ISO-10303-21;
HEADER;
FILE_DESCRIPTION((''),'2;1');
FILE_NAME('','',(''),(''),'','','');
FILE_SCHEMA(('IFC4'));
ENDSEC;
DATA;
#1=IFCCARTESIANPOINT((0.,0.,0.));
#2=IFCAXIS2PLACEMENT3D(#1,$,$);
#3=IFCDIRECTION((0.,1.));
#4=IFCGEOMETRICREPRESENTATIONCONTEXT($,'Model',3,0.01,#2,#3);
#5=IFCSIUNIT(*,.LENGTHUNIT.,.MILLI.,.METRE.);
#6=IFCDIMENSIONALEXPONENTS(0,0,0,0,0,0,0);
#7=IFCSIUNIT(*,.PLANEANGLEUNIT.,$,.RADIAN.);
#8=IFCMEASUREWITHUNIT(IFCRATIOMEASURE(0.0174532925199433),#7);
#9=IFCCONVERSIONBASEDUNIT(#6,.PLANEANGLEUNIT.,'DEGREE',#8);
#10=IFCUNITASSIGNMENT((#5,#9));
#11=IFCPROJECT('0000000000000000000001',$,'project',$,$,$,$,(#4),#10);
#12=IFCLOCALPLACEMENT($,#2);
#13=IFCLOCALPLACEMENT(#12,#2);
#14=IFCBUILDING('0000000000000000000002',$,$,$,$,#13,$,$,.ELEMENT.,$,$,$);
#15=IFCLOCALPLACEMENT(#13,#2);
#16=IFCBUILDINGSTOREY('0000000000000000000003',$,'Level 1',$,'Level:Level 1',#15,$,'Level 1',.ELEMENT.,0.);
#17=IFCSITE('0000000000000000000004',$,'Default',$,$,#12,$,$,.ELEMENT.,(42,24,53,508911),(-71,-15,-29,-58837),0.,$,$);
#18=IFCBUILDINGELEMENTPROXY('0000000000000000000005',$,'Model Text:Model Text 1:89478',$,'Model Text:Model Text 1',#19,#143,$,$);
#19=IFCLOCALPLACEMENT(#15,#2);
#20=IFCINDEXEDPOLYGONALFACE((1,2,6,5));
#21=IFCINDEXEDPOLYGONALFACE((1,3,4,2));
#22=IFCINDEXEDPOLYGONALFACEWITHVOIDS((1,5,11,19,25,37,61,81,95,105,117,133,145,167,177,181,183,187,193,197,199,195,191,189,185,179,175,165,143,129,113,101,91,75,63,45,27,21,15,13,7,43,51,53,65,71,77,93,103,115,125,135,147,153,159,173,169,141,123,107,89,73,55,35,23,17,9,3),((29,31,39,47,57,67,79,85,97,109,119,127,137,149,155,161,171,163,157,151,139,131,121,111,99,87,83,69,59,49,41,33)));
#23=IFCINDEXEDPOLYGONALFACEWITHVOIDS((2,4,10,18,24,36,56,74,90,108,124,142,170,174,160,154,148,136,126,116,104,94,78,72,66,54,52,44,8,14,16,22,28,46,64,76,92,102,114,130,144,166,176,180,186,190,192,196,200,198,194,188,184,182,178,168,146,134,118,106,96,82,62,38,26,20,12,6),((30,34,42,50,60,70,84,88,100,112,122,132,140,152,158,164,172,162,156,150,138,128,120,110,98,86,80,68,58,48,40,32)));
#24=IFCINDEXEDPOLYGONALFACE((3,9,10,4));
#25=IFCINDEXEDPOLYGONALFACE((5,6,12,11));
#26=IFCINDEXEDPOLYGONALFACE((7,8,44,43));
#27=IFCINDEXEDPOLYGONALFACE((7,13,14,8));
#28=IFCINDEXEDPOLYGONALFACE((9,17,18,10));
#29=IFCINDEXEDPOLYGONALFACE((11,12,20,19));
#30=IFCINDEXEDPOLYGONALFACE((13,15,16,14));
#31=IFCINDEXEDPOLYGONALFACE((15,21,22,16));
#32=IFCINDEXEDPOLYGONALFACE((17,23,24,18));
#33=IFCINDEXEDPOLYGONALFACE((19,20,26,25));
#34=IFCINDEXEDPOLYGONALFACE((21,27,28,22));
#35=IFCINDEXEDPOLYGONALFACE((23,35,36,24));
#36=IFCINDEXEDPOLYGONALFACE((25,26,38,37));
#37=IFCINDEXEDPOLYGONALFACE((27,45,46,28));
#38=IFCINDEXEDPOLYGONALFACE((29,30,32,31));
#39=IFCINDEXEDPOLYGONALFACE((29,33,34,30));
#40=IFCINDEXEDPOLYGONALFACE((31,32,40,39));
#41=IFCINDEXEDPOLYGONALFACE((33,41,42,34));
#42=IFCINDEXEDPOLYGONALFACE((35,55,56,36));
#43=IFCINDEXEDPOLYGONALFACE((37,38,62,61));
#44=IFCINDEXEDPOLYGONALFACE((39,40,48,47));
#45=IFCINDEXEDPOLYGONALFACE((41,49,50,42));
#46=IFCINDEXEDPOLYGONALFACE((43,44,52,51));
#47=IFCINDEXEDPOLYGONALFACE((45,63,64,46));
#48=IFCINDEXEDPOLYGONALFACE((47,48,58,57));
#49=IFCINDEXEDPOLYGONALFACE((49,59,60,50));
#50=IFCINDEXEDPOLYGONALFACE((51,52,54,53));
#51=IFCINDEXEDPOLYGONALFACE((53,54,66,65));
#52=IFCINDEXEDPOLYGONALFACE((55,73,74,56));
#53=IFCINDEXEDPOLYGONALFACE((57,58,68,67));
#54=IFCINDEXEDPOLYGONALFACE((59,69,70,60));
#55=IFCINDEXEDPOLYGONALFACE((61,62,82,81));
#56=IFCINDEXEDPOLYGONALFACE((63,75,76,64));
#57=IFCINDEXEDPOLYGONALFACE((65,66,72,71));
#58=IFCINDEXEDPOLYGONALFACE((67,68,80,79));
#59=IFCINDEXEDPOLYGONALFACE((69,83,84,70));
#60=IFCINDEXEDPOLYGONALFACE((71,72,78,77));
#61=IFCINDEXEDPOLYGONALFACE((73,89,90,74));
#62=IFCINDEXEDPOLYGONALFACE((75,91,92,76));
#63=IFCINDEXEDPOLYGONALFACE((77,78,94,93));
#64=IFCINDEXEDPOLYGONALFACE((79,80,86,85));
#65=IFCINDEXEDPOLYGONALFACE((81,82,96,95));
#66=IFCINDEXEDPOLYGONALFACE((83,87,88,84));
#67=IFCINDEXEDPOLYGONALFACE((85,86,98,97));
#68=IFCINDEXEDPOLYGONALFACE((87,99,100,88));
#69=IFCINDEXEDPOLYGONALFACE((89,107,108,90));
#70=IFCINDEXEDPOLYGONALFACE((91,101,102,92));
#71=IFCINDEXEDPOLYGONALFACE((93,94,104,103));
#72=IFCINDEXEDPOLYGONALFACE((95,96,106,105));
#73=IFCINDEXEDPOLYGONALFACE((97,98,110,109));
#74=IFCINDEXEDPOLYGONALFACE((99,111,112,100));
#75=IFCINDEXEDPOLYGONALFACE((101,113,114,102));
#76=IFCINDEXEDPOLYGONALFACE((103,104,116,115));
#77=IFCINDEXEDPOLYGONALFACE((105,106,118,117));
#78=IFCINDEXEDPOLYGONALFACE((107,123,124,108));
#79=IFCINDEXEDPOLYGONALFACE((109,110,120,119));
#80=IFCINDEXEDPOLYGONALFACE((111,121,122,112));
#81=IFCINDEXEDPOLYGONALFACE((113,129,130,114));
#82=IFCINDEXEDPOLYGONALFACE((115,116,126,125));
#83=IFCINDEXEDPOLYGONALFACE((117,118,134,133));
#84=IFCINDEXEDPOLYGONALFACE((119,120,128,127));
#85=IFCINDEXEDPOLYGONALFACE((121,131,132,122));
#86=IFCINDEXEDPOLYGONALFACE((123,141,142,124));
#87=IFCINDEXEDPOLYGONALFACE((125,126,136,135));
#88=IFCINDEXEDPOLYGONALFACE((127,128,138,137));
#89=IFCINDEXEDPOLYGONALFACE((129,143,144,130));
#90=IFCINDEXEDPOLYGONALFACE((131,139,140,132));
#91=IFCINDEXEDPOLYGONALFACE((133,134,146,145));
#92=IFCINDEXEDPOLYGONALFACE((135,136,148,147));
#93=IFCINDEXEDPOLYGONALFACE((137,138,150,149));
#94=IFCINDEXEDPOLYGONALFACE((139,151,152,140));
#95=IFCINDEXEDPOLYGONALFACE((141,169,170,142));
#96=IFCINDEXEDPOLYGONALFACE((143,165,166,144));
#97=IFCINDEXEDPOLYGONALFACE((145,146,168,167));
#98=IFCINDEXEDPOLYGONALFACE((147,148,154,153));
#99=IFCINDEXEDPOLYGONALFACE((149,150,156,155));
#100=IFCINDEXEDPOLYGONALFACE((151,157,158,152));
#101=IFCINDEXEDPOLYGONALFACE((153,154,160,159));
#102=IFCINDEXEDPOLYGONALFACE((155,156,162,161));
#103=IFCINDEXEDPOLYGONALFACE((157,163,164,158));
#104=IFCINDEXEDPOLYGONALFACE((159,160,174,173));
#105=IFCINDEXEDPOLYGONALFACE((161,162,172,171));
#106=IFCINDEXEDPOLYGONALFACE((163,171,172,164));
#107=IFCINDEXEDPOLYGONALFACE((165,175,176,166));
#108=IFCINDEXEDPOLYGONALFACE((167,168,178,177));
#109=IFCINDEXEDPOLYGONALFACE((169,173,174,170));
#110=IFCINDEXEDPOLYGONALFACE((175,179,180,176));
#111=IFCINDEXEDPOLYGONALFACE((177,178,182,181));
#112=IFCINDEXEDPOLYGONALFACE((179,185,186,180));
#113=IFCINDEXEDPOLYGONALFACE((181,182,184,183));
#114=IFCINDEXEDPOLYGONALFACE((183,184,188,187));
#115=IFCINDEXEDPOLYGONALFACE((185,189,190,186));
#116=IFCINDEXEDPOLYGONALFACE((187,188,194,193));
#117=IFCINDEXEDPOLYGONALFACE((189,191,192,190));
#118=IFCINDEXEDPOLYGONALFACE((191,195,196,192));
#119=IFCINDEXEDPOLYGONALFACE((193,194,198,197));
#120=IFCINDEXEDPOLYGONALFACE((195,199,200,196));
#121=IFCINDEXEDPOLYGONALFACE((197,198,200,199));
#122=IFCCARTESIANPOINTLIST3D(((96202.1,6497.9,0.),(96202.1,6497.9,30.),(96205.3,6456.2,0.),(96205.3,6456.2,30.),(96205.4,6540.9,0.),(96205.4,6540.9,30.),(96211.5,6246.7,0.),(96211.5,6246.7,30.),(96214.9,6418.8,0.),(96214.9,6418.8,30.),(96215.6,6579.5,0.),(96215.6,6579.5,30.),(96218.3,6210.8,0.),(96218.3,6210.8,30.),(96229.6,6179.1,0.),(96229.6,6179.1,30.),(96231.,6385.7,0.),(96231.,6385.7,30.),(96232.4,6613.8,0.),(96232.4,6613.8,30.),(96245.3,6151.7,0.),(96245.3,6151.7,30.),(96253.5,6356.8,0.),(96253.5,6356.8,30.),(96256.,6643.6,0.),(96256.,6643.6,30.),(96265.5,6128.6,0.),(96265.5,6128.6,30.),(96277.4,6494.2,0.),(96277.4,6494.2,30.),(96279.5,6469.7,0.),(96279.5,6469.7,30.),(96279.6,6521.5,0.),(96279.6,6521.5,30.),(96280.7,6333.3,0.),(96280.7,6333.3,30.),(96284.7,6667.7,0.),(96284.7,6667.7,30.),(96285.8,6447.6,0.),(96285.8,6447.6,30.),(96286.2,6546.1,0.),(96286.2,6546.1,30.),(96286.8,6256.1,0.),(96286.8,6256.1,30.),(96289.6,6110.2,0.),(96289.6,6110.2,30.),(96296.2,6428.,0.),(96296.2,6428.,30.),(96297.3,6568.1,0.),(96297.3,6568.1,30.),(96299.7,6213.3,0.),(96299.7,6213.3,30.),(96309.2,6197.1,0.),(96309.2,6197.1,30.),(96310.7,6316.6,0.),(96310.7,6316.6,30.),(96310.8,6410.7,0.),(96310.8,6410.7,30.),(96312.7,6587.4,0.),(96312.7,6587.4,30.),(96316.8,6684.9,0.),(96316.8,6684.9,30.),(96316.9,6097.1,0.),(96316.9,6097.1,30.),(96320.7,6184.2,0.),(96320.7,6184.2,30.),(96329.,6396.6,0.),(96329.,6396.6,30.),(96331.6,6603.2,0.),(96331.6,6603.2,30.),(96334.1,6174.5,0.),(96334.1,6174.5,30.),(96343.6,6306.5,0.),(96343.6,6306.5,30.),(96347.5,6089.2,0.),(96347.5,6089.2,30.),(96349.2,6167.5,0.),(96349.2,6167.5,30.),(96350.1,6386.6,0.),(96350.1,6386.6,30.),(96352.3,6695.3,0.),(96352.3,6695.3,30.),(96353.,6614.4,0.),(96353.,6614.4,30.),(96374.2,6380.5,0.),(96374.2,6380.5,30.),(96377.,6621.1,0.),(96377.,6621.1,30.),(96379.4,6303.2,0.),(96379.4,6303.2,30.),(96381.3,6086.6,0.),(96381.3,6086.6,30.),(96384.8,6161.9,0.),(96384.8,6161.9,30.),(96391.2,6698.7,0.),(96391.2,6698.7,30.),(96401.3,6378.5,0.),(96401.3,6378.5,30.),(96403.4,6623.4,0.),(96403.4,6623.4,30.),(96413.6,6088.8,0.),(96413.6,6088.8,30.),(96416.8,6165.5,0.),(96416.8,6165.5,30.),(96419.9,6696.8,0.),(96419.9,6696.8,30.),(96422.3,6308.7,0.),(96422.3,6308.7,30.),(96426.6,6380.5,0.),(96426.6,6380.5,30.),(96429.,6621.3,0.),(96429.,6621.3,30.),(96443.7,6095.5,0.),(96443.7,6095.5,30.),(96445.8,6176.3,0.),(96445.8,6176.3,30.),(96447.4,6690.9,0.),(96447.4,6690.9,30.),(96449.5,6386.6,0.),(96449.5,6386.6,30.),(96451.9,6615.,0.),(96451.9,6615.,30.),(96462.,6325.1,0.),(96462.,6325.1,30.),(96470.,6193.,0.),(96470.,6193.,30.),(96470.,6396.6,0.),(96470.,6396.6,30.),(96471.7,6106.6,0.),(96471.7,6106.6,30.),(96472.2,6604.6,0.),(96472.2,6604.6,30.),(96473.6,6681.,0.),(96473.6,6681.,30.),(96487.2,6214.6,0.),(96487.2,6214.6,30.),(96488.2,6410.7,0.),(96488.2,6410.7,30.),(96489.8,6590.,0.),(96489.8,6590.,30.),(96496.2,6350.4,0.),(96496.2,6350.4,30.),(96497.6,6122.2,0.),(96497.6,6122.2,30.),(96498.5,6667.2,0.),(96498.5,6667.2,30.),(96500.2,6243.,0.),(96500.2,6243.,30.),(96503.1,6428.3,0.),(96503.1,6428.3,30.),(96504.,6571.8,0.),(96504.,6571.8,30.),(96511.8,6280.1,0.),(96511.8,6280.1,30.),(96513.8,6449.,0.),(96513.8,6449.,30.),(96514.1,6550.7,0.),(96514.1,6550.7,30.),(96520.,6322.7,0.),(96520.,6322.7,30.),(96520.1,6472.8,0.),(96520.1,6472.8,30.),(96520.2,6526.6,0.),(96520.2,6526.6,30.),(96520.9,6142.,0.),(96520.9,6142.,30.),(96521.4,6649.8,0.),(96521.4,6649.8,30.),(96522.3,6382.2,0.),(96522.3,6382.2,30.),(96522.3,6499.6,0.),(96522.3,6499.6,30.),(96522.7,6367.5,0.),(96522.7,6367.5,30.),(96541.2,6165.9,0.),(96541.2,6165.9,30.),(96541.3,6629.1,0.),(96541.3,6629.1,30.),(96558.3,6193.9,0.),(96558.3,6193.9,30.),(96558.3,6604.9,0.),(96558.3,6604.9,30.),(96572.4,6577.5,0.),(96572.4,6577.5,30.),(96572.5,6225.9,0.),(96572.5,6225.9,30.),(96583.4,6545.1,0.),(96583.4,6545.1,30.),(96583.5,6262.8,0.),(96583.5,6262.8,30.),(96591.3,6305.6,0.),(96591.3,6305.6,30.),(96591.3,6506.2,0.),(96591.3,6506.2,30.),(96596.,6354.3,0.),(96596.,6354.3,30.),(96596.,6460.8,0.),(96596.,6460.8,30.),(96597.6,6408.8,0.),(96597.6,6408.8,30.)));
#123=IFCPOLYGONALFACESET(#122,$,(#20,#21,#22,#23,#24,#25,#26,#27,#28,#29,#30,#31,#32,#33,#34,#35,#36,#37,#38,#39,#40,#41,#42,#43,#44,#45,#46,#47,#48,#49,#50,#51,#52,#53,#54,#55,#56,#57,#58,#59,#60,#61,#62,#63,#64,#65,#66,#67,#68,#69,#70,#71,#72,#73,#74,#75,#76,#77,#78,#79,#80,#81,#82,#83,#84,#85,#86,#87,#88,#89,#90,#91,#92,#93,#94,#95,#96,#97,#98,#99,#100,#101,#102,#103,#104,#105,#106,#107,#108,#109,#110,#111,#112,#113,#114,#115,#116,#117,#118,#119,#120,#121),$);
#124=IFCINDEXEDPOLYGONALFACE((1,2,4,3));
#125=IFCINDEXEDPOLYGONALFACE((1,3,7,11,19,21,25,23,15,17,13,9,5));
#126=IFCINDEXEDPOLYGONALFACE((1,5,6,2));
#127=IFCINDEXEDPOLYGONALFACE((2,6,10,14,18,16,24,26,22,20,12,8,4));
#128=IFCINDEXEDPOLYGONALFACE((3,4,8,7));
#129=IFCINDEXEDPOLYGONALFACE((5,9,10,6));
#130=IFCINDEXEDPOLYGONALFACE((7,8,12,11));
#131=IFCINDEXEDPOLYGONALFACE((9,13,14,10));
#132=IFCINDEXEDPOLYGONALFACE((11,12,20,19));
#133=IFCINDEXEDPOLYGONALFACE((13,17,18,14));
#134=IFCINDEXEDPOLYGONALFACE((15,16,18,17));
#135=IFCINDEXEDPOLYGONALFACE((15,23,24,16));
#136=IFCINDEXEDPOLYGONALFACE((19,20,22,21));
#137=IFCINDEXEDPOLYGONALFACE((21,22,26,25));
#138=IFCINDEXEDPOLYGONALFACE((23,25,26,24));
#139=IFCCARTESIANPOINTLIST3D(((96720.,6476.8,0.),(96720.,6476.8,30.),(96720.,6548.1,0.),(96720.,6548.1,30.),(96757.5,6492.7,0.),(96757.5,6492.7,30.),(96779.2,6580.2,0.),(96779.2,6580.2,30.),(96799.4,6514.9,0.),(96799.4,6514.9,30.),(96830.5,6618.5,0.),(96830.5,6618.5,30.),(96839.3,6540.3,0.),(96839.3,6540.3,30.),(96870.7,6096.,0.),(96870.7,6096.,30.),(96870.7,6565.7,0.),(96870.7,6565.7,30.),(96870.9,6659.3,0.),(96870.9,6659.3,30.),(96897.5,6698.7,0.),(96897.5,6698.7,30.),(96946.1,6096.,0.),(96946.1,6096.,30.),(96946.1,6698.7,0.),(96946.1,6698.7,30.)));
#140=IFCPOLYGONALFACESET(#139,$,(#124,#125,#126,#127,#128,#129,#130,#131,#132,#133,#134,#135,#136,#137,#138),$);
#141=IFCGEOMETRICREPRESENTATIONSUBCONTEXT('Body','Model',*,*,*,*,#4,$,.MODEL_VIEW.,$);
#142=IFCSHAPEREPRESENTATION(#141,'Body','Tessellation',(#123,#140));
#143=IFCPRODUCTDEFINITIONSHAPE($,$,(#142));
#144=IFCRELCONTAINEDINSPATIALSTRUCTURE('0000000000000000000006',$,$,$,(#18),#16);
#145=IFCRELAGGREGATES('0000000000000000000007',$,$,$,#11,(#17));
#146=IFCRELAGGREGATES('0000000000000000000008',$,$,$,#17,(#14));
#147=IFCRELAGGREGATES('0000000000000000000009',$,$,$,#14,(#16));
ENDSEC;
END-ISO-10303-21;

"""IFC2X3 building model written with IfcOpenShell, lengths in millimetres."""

from ifc_helpers import new_model, entity, si_unit, converted_unit, direction, frame, origin, place, context, subcontext, project, spatial, polyline, outline, extrude, element, save


model = new_model("IFC2X3")

# Units and contexts
model_context = context("Model", 3, precision=0.01, world=origin(), true_north=direction((0.0, 1.0)))
body_context = subcontext(model_context, "Body", "Model", "MODEL_VIEW")
ifc_project = project(units=[si_unit("LENGTHUNIT", "METRE", prefix="MILLI"), converted_unit("PLANEANGLEUNIT", "DEGREE", entity("IfcRatioMeasure", 0.0174532925199433), si_unit("PLANEANGLEUNIT", "RADIAN"), dimensions=[0, 0, 0, 0, 0, 0, 0])], contexts=[model_context])

# Site, building, storey
site_placement = place(None, origin())
site = spatial("IfcSite", under=ifc_project, at=site_placement, Name="Default", CompositionType="ELEMENT", RefLatitude=(42, 24, 53, 508911), RefLongitude=(-71, -15, -29, -58837), RefElevation=0.0)
building_placement = place(site_placement, origin())
building = spatial("IfcBuilding", under=site, at=building_placement, CompositionType="ELEMENT")
storey_placement = place(building_placement, origin())
storey = spatial("IfcBuildingStorey", under=building, at=storey_placement, Name="Level 1", ObjectType="Level:Level 1", LongName="Level 1", CompositionType="ELEMENT", Elevation=0.0)

# Building element proxy
proxy_1_placement = place(storey_placement, origin())
element("IfcBuildingElementProxy", 1, at=proxy_1_placement, inside=storey, Name="Model Text:Model Text 1:89478", ObjectType="Model Text:Model Text 1", context=body_context, shape_type="SweptSolid", body=[
    extrude(outline(polyline([(63.9, -207.4), (100.4, -207.4), (133.6, -202.3), (163.4, -191.9), (189.9, -176.3), (212.5, -156.1), (230.5, -131.7), (243.9, -103.1), (252.8, -70.4), (256.6, -38.2), (255.6, -7.4), (249.9, 22.2), (239.4, 50.6), (224.2, 77.1), (204.5, 101.5), (180.3, 123.5), (151.4, 143.4), (117.2, 161.0), (76.6, 176.7), (29.6, 190.4), (-23.7, 202.1), (-75.0, 210.2), (-120.5, 214.0), (-160.2, 213.5), (-194.1, 208.7), (-223.7, 199.9), (-250.5, 187.7), (-274.6, 172.0), (-296.0, 152.8), (-314.2, 130.8), (-328.7, 106.9), (-339.6, 81.0), (-346.9, 53.2), (-350.7, 14.3), (-347.2, -22.5), (-336.2, -57.2), (-317.8, -89.9), (-292.9, -118.6), (-262.4, -141.6), (-226.4, -158.7), (-184.7, -170.0), (-143.2, -174.6), (-104.6, -172.1), (-69.1, -162.4), (-36.5, -145.7), (-8.4, -123.4), (13.6, -97.0), (29.6, -66.5), (39.6, -32.0), (42.2, 11.2), (33.4, 53.3), (14.9, 91.6), (-11.5, 123.1), (3.0, 120.8), (46.6, 109.8), (86.9, 93.9), (121.2, 75.6), (146.7, 57.5), (164.6, 36.5), (176.6, 9.7), (181.8, -20.8), (179.4, -52.9), (167.3, -86.8), (157.6, -100.4), (145.5, -111.8), (130.8, -120.7), (113.0, -127.0), (68.6, -131.7), (63.9, -207.4)]), holes=[polyline([(-126.9, 145.0), (-100.9, 137.9), (-78.7, 127.2), (-60.4, 112.9), (-45.8, 94.9), (-35.4, 74.4), (-29.3, 52.4), (-27.7, 28.8), (-30.4, 3.6), (-37.4, -22.6), (-47.8, -45.2), (-61.6, -64.1), (-78.8, -79.4), (-98.5, -90.5), (-119.8, -97.1), (-142.6, -99.1), (-167.1, -96.6), (-193.5, -89.4), (-216.5, -78.3), (-236.0, -63.4), (-252.1, -44.6), (-264.0, -23.1), (-271.1, 0.0), (-273.3, 24.8), (-270.6, 51.2), (-263.8, 75.9), (-253.4, 97.3), (-239.3, 115.2), (-221.7, 129.8), (-201.2, 140.4), (-178.6, 146.5), (-153.8, 148.0), (-126.9, 145.0)])]), frame((96403.4, 6348.0, 0.0), z_axis=(0.0, 0.0, 1.0), x_axis=(0.185967, -0.982556, 0.0)), (0.0, 0.0, 1.0), 30.0),
    extrude(outline(polyline([(-410.6, -111.6), (192.1, -111.6), (192.1, -63.1), (152.7, -36.4), (111.9, 4.0), (73.6, 55.2), (41.4, 114.4), (-29.8, 114.4), (-13.9, 77.0), (8.3, 35.1), (33.7, -4.8), (59.1, -36.3), (-410.6, -36.3), (-410.6, -111.6)])), frame((96834.5, 6506.6, 0.0), z_axis=(0.0, 0.0, 1.0), x_axis=(0.0, 1.0, 0.0)), (0.0, 0.0, 1.0), 30.0),
])

save(model, "model.ifc")
